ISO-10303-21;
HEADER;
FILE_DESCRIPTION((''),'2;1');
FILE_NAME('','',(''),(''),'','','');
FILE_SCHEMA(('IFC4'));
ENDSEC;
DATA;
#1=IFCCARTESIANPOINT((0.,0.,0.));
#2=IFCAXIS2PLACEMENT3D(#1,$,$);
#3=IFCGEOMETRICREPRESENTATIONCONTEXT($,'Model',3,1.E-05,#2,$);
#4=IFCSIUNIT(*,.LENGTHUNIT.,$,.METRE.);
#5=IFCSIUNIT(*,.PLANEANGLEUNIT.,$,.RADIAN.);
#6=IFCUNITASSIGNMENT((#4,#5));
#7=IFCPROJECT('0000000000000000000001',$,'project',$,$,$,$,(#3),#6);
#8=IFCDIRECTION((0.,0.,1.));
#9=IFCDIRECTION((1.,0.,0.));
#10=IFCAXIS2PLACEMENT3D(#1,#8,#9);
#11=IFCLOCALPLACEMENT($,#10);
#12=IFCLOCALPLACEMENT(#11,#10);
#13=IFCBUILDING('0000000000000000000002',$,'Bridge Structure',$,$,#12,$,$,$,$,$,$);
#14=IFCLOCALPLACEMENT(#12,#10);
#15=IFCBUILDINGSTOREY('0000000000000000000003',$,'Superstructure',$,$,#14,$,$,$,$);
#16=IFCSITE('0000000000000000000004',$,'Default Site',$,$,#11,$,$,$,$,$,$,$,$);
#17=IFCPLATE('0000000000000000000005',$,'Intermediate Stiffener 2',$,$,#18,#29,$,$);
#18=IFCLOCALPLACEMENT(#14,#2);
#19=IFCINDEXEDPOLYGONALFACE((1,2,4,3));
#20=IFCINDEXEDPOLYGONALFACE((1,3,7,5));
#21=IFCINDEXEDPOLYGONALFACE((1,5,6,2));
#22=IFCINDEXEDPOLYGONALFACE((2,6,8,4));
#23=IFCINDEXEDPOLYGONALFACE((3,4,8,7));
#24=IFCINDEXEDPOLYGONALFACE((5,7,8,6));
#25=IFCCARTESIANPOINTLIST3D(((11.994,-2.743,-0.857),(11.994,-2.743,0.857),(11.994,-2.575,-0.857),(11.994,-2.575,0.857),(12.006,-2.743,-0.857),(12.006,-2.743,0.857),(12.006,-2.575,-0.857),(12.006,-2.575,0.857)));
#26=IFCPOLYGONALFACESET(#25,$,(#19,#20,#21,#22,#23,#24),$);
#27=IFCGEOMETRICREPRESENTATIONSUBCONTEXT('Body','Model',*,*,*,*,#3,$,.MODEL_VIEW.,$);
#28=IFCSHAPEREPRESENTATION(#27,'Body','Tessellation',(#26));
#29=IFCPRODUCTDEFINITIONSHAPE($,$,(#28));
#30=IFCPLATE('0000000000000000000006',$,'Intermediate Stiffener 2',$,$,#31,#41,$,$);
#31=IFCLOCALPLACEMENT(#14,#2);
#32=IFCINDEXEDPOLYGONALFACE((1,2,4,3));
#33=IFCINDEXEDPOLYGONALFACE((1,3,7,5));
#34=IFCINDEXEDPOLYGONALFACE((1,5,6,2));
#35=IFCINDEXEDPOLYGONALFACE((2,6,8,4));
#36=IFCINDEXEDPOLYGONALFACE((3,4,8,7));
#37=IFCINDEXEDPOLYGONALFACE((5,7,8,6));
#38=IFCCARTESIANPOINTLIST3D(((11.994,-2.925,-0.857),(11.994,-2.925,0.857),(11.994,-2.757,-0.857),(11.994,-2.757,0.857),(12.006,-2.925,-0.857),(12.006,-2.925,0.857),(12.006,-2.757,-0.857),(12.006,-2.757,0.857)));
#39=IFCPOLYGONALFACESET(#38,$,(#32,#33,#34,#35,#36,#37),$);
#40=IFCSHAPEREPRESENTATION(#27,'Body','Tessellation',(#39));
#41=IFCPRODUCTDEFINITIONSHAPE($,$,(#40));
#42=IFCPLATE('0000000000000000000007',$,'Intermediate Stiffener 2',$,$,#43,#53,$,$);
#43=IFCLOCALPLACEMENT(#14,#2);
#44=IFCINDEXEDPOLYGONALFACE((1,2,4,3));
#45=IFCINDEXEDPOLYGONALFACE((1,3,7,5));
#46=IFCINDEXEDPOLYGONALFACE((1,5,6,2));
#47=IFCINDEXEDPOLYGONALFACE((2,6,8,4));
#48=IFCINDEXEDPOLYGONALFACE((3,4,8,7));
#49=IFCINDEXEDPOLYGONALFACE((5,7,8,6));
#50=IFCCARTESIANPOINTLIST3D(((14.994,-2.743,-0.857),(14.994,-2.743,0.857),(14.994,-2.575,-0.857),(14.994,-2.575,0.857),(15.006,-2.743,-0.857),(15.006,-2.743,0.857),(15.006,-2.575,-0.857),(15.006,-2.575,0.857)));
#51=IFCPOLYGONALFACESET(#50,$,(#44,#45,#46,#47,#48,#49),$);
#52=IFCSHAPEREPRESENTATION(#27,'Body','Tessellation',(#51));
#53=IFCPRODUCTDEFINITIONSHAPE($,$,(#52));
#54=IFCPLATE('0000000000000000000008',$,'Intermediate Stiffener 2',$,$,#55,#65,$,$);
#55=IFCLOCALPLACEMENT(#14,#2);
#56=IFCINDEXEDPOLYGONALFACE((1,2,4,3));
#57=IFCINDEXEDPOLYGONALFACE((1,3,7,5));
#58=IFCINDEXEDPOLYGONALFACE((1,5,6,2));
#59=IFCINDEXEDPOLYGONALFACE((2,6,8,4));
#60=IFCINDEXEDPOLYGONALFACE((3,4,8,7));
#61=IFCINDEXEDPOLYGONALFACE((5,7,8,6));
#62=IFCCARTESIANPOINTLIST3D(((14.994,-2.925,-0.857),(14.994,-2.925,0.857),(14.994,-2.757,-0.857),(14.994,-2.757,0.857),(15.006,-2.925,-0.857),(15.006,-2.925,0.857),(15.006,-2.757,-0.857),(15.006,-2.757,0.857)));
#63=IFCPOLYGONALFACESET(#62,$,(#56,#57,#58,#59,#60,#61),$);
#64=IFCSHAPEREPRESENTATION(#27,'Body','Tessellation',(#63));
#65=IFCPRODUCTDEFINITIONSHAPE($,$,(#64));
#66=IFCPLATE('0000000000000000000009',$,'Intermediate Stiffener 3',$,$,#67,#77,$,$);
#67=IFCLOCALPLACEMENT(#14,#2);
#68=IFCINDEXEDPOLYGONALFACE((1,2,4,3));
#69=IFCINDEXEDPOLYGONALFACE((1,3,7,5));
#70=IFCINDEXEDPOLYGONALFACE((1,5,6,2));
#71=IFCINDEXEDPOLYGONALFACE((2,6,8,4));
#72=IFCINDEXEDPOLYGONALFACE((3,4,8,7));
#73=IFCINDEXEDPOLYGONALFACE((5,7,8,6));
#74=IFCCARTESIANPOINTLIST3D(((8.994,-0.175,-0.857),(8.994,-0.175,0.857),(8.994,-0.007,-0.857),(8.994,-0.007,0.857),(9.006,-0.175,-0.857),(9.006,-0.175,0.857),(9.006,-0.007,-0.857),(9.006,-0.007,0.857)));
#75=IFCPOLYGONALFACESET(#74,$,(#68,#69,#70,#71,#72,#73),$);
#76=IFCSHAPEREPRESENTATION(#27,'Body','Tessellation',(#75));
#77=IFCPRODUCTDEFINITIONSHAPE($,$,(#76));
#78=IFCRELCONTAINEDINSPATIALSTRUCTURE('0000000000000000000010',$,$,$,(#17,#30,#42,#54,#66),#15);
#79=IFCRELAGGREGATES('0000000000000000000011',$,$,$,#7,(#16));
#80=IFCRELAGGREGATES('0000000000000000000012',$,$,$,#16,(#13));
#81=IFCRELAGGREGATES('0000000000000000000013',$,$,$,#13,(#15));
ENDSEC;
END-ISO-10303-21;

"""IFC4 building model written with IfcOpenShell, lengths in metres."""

from ifc_helpers import new_model, si_unit, frame, origin, origin_with_axes, origin_2d_with_axis, place, context, subcontext, project, spatial, rectangle, extrude, element, save


model = new_model("IFC4")

# Units and contexts
model_context = context("Model", 3, precision=1e-05, world=origin())
body_context = subcontext(model_context, "Body", "Model", "MODEL_VIEW")
ifc_project = project(units=[si_unit("LENGTHUNIT", "METRE"), si_unit("PLANEANGLEUNIT", "RADIAN")], contexts=[model_context])

# Site, building, storey
site_placement = place(None, origin_with_axes())
site = spatial("IfcSite", under=ifc_project, at=site_placement, Name="Default Site")
building_placement = place(site_placement, origin_with_axes())
building = spatial("IfcBuilding", under=site, at=building_placement, Name="Bridge Structure")
storey_placement = place(building_placement, origin_with_axes())
storey = spatial("IfcBuildingStorey", under=building, at=storey_placement, Name="Superstructure")

# Plates
for number, where, z_axis, x_axis, name in (
    (1, (12.0, -2.659, -0.857), (0.0, 0.0, 1.0), (1.0, 0.0, 0.0), "Intermediate Stiffener 2"),
    (2, (12.0, -2.841, -0.857), (0.0, 0.0, 1.0), (1.0, 0.0, 0.0), "Intermediate Stiffener 2"),
    (3, (15.0, -2.659, -0.857), (0.0, 0.0, 1.0), (1.0, 0.0, 0.0), "Intermediate Stiffener 2"),
    (4, (15.0, -2.841, -0.857), (0.0, 0.0, 1.0), (1.0, 0.0, 0.0), "Intermediate Stiffener 2"),
    (5, (9.0, -0.091, -0.857), (0.0, 0.0, 1.0), (1.0, 0.0, 0.0), "Intermediate Stiffener 3"),
):
    element("IfcPlate", number, at=place(storey_placement, frame(where, z_axis=z_axis, x_axis=x_axis)), inside=storey, Name=name, context=body_context, shape_type="SweptSolid", body=[
        extrude(rectangle(XDim=0.012, YDim=0.168, at=origin_2d_with_axis()), origin_with_axes(), (0.0, 0.0, 1.0), 1.714),
    ])

save(model, "model.ifc")
